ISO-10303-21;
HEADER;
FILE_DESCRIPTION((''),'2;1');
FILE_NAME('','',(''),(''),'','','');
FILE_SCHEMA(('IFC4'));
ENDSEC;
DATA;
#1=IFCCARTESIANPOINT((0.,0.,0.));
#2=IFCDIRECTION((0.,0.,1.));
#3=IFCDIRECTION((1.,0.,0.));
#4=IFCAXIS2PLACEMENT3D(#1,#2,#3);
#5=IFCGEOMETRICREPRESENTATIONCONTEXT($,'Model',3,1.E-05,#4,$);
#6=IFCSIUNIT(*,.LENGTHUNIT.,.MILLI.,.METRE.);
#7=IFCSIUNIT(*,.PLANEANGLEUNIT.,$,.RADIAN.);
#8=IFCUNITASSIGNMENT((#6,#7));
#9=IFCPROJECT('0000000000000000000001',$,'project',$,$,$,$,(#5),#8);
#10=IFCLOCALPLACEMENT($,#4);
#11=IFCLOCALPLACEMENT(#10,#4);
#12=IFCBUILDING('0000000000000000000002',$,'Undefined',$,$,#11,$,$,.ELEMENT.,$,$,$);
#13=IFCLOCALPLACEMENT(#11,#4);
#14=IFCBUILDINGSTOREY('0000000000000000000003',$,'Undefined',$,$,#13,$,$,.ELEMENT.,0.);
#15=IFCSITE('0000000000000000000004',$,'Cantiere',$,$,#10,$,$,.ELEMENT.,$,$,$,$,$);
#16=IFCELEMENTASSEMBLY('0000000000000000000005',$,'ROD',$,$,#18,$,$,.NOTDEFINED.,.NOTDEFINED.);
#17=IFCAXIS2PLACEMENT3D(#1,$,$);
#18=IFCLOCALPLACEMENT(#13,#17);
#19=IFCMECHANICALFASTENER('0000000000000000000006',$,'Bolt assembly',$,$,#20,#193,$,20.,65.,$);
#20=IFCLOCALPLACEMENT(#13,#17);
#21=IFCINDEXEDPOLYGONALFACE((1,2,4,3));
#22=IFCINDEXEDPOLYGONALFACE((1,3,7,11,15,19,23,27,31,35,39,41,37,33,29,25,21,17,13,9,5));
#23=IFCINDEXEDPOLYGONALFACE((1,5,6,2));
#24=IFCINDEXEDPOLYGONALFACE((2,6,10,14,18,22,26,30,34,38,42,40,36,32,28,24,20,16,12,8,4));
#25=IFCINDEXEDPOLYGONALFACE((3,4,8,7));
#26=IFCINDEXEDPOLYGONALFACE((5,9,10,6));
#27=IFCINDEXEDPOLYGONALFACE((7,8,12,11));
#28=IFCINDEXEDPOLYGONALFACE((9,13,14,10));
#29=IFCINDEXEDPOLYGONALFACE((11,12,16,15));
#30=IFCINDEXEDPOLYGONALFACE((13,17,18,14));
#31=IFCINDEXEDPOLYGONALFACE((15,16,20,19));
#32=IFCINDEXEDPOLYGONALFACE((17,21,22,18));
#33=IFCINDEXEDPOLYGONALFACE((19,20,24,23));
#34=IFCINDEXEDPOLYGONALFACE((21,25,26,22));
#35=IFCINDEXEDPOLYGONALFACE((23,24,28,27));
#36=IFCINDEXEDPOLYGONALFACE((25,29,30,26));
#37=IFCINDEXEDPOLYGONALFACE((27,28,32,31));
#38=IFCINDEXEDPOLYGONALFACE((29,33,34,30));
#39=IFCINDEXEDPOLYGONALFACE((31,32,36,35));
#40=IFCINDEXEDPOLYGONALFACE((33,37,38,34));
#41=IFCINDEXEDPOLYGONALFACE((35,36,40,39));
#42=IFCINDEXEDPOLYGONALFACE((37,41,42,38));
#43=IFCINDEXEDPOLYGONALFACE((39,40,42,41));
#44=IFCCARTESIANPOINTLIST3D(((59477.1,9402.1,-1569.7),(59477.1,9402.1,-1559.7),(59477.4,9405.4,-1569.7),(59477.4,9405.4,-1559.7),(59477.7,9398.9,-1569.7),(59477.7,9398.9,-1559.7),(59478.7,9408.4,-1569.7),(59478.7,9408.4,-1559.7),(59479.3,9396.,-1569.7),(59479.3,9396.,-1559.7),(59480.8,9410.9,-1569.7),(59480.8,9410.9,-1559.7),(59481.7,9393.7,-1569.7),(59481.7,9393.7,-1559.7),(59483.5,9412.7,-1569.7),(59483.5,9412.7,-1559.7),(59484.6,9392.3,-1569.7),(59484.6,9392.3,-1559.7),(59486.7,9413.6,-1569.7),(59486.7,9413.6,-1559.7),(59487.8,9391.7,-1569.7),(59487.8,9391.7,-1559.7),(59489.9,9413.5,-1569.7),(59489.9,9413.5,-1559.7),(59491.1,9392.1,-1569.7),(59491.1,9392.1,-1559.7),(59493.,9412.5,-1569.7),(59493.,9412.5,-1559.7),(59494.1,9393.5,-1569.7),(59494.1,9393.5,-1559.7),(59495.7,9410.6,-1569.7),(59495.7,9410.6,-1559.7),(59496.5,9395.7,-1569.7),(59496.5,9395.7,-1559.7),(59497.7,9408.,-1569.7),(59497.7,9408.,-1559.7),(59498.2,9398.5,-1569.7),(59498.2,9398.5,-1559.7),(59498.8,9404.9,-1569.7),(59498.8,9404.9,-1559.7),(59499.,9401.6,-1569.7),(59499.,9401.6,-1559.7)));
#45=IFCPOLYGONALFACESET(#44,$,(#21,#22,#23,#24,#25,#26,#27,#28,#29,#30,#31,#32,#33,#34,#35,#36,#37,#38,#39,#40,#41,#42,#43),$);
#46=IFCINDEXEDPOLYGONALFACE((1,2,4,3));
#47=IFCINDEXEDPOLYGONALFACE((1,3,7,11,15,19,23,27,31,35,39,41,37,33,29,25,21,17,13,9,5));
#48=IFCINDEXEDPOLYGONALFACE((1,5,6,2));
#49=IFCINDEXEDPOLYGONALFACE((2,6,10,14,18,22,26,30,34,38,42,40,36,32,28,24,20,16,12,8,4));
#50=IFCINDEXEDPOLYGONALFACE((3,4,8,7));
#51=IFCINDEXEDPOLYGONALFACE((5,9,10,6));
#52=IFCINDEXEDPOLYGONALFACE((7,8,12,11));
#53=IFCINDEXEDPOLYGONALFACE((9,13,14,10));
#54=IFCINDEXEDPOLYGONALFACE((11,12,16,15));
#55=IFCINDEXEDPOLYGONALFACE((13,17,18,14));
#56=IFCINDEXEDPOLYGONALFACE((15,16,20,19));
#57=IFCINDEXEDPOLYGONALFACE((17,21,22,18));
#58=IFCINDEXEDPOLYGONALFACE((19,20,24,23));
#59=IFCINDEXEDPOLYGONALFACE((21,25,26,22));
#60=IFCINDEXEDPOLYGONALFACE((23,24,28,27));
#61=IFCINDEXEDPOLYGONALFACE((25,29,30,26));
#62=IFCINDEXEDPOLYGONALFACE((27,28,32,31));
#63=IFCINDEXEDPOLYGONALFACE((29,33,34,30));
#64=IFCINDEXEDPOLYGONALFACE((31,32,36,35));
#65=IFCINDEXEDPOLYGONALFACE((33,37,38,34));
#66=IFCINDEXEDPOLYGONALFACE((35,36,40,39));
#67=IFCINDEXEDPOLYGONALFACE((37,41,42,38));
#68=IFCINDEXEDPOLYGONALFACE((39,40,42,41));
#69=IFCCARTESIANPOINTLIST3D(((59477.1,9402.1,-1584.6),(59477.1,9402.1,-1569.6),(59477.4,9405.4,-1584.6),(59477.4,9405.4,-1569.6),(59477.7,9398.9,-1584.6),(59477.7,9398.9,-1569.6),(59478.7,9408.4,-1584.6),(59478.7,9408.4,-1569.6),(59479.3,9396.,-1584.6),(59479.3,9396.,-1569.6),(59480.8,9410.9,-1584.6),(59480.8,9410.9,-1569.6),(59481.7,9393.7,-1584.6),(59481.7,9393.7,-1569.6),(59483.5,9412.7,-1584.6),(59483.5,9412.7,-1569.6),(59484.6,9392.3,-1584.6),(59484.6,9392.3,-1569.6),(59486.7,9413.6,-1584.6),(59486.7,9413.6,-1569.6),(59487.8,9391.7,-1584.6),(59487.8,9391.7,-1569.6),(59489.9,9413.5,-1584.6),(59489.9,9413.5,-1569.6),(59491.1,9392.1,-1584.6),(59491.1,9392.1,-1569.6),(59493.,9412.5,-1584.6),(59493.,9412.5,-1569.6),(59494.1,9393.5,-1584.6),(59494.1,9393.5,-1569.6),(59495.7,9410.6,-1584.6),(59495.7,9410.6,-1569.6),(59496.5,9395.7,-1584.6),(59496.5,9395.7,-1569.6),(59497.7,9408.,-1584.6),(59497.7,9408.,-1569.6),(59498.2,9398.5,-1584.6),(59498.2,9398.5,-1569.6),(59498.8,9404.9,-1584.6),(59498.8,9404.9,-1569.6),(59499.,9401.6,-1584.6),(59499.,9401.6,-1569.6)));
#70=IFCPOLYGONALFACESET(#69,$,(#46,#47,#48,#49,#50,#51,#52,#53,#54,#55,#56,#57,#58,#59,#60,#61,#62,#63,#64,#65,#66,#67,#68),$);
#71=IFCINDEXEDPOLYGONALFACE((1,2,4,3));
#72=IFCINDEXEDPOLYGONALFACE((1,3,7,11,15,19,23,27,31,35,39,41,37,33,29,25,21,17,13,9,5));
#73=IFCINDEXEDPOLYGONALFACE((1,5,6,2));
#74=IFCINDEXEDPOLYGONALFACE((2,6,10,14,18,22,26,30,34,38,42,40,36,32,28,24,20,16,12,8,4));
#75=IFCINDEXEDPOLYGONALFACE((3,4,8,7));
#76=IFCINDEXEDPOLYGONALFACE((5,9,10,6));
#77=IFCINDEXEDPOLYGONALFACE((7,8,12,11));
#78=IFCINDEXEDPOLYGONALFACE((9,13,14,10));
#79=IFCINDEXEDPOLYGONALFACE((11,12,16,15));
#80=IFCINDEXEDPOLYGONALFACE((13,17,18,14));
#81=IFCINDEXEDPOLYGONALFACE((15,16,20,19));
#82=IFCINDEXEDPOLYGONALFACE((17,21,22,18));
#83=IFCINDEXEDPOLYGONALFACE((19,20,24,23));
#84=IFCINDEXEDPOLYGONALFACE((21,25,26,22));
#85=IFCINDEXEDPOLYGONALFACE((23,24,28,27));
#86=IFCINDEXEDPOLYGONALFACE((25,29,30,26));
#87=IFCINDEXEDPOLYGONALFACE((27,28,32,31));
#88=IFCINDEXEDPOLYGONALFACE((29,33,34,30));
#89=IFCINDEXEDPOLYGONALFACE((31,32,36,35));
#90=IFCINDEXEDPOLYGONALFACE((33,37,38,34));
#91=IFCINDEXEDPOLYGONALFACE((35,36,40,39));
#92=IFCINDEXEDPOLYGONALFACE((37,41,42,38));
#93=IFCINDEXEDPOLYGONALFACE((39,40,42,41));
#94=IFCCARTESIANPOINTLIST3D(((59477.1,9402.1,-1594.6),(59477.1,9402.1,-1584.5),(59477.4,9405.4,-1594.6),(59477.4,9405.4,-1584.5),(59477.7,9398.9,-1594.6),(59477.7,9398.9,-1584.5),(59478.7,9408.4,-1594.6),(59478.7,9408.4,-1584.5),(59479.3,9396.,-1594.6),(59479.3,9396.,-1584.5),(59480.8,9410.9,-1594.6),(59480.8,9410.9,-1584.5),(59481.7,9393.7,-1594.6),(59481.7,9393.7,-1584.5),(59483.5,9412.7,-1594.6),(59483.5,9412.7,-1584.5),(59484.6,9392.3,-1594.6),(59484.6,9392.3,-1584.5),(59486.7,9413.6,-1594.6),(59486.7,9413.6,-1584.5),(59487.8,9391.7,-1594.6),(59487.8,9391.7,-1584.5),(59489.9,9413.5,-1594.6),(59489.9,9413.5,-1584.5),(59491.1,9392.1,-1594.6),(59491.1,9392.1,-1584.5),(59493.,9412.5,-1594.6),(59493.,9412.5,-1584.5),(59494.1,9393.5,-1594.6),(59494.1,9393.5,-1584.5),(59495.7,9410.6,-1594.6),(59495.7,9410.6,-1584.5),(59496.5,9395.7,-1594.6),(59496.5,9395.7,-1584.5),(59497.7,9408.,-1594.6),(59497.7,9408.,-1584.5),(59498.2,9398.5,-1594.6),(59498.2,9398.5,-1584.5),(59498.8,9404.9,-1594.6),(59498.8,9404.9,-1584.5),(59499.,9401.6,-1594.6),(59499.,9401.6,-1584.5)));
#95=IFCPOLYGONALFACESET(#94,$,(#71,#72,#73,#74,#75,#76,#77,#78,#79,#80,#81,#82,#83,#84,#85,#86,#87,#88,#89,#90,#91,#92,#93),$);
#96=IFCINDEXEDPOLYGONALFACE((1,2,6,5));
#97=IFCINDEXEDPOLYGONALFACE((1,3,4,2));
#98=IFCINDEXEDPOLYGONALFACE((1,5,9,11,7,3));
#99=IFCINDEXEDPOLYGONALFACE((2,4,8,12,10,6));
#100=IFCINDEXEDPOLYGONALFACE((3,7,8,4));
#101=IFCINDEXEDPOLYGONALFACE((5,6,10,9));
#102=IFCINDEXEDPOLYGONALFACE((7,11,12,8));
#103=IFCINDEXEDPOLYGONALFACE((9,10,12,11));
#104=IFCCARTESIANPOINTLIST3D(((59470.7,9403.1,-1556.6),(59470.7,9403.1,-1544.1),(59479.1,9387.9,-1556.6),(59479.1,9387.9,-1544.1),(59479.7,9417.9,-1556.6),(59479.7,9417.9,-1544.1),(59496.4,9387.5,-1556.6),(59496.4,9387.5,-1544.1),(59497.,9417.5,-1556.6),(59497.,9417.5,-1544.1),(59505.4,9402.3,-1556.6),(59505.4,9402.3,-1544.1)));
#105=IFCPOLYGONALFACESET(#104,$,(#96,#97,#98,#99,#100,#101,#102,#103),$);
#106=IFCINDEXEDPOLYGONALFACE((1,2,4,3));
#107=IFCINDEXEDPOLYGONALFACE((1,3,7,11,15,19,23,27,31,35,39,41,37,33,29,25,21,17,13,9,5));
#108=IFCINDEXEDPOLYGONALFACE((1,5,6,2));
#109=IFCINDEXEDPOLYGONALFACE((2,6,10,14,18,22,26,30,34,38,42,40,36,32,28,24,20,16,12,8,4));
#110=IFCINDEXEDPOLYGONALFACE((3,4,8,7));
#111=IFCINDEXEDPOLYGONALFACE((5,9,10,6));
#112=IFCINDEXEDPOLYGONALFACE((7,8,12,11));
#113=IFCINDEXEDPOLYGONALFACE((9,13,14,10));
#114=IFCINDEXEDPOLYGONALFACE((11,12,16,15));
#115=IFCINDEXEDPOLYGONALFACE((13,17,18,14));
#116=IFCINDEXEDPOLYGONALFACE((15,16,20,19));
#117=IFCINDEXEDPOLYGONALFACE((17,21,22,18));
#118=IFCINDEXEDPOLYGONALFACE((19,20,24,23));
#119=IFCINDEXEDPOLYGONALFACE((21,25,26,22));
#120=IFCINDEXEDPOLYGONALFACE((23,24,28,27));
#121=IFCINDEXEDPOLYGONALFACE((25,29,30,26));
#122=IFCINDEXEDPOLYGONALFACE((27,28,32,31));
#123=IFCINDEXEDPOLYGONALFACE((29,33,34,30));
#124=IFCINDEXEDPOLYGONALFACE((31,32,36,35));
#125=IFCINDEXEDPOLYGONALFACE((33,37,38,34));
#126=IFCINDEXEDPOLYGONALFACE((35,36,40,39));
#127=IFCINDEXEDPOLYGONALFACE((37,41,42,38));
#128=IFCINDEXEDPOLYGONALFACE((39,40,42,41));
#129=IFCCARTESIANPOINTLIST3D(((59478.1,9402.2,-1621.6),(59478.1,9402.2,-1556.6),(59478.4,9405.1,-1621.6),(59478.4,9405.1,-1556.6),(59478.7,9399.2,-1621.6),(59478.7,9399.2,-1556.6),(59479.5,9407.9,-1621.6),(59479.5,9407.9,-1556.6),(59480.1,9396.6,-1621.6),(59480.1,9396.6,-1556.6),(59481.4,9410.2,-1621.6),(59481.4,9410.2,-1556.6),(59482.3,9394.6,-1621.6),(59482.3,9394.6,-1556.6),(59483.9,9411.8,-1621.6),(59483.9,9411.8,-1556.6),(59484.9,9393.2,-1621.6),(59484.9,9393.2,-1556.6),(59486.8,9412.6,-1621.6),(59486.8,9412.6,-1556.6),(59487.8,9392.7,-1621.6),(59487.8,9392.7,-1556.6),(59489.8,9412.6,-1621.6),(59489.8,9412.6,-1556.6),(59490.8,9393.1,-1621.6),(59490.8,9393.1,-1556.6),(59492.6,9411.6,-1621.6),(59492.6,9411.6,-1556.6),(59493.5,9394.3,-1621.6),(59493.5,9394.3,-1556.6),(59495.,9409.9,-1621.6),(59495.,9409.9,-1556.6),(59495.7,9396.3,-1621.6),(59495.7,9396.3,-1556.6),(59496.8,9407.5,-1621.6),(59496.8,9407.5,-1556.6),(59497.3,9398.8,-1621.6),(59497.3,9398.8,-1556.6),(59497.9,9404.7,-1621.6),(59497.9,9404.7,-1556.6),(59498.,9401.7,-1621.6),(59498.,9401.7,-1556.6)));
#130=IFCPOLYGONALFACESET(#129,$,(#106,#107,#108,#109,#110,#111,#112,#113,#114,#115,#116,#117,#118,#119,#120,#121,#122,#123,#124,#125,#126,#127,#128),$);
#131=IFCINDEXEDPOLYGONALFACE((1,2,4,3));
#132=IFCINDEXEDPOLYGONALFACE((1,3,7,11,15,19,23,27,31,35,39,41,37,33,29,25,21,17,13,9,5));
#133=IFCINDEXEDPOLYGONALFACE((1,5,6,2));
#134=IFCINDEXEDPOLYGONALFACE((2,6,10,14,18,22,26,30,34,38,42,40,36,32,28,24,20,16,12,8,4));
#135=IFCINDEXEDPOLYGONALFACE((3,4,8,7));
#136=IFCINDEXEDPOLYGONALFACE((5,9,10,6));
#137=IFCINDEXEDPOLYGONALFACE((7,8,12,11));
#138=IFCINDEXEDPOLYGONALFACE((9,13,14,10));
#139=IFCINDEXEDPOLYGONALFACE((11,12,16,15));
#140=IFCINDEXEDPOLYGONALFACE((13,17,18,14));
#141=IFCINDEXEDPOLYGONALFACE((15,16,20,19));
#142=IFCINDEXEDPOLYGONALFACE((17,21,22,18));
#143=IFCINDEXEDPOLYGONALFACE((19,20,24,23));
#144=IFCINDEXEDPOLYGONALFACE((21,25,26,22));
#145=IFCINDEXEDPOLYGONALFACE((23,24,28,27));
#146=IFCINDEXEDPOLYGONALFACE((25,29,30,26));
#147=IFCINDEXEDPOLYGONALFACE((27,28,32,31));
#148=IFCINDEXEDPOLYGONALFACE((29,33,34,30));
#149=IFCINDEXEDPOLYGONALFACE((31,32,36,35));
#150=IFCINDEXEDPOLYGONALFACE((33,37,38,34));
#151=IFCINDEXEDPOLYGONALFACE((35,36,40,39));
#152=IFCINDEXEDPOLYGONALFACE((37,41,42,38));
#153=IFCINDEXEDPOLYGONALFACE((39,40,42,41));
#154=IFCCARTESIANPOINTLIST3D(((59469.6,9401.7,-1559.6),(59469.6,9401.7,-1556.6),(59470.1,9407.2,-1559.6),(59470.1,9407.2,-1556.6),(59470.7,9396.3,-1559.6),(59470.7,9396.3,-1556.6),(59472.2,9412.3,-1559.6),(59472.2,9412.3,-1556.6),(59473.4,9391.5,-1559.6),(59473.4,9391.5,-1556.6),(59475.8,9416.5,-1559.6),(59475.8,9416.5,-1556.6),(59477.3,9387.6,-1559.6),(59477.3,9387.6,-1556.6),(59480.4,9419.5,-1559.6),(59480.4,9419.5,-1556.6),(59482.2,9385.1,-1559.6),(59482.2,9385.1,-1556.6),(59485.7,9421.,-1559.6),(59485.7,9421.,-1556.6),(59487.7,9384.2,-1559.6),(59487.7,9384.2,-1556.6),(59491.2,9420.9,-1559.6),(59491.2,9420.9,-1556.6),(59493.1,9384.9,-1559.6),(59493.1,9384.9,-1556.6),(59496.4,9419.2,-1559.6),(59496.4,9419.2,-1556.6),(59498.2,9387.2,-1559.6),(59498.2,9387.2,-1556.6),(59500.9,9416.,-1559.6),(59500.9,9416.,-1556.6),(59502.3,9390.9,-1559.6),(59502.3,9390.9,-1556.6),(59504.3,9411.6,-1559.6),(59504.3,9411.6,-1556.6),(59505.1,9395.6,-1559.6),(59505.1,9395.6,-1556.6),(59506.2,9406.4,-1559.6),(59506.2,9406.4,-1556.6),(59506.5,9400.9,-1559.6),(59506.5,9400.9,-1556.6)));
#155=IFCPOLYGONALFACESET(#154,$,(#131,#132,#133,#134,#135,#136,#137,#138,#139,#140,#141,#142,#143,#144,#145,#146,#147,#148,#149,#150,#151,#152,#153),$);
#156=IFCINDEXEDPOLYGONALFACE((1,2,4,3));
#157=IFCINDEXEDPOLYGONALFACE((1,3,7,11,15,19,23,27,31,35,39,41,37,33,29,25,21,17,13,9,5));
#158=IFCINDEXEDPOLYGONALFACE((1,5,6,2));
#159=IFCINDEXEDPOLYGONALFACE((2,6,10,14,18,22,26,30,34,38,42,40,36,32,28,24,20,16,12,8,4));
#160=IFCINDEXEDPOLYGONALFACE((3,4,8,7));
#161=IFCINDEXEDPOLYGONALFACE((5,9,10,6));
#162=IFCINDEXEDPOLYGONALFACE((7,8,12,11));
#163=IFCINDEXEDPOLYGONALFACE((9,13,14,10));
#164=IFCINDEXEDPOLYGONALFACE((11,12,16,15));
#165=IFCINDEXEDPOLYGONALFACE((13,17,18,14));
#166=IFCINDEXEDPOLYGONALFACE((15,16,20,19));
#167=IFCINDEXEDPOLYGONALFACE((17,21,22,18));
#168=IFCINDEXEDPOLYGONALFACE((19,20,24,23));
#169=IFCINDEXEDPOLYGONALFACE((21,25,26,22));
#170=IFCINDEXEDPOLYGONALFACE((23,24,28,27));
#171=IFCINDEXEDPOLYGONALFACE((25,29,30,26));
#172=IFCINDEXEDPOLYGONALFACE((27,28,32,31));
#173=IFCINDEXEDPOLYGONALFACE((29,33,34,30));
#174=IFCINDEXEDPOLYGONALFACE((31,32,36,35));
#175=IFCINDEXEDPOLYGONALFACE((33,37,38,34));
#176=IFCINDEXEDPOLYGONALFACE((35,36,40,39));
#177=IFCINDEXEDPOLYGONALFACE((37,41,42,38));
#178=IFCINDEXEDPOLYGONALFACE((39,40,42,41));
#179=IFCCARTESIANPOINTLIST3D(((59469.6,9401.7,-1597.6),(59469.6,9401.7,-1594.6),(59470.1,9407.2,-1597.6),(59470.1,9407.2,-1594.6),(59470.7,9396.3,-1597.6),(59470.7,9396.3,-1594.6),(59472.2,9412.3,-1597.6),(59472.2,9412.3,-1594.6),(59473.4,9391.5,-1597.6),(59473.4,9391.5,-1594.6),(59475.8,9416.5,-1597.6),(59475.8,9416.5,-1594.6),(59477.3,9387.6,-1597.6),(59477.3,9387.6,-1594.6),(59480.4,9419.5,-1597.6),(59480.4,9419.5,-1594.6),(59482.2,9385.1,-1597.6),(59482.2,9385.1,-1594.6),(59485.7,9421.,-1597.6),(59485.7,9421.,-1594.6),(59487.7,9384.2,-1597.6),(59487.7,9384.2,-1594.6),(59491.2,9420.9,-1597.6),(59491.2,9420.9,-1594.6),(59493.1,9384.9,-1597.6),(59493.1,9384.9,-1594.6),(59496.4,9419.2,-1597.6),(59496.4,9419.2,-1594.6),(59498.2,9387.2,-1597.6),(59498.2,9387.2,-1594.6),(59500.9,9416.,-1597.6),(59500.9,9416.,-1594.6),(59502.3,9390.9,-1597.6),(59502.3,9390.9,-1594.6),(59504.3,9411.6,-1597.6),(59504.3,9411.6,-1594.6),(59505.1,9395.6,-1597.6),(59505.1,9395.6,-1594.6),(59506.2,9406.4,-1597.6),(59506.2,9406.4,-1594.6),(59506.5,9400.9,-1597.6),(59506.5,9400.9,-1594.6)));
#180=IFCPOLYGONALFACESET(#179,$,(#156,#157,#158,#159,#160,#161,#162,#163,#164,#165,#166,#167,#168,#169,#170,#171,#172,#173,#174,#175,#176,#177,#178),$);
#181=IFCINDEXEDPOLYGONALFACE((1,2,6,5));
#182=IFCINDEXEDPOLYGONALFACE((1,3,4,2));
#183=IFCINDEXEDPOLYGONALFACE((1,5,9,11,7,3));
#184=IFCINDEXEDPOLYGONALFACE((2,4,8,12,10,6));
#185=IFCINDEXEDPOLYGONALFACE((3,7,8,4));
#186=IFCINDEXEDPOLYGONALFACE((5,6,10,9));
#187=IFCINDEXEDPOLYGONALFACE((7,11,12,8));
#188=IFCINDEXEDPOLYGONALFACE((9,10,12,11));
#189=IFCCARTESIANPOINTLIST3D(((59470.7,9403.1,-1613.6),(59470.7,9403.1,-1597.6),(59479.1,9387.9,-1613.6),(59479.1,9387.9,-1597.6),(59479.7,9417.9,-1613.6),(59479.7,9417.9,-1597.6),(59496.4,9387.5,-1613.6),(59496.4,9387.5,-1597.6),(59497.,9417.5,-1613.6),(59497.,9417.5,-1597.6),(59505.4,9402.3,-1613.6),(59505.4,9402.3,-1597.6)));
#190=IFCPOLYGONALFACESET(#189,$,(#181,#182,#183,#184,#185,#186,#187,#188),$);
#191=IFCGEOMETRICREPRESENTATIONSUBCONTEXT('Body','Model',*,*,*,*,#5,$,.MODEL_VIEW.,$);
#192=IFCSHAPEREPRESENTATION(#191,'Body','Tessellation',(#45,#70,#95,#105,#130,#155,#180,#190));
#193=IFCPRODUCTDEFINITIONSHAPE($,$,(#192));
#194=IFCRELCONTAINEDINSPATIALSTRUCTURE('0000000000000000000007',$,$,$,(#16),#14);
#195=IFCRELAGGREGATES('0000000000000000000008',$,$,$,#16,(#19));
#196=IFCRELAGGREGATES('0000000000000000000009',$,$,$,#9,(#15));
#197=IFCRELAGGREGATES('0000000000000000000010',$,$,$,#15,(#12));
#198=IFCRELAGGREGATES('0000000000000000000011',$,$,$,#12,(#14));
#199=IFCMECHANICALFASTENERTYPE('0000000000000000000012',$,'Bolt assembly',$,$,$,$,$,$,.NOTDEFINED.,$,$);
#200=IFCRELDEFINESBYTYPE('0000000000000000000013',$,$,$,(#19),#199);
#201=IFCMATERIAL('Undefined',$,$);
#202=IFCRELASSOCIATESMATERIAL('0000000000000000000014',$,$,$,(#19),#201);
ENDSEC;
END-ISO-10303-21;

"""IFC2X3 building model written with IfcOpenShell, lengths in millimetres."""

from ifc_helpers import new_model, si_unit, frame, origin_with_axes, origin_2d_with_axis, place, context, subcontext, project, spatial, polyline, circle, outline, extrude, source, transform, mapped, material, type_object, element, aggregate, save


model = new_model("IFC2X3")

# Units and contexts
model_context = context("Model", 3, precision=1e-05, world=origin_with_axes())
body_context = subcontext(model_context, "Body", "Model", "MODEL_VIEW")
ifc_project = project(units=[si_unit("LENGTHUNIT", "METRE", prefix="MILLI"), si_unit("PLANEANGLEUNIT", "RADIAN")], contexts=[model_context])

# Site, building, storey
site_placement = place(None, origin_with_axes())
site = spatial("IfcSite", under=ifc_project, at=site_placement, Name="Cantiere", CompositionType="ELEMENT")
building_placement = place(site_placement, origin_with_axes())
building = spatial("IfcBuilding", under=site, at=building_placement, Name="Undefined", CompositionType="ELEMENT")
storey_placement = place(building_placement, origin_with_axes())
storey = spatial("IfcBuildingStorey", under=building, at=storey_placement, Name="Undefined", CompositionType="ELEMENT", Elevation=0.0)

# Element assembly
assembly_1_placement = place(storey_placement, origin_with_axes())
assembly_1 = element("IfcElementAssembly", 1, at=assembly_1_placement, inside=storey, Name="ROD", AssemblyPlace="NOTDEFINED", PredefinedType="NOTDEFINED")

# Mechanical fastener
ifc_material_1 = material(Name="Undefined")
mechanical_fastener_type = type_object("IfcMechanicalFastenerType", Name="Bolt assembly")
shared_shape_1 = source(origin_with_axes(), body_context, "Body", "SweptSolid", [
    extrude(circle(Radius=11.0, at=origin_2d_with_axis()), frame((0.0, 0.1, 0.0), z_axis=(0.0, 1.0, 0.0), x_axis=(1.0, 0.0, 0.0)), (0.0, 0.0, 1.0), 10.0),
    extrude(circle(Radius=11.0, at=origin_2d_with_axis()), frame((0.0, 10.0, 0.0), z_axis=(0.0, 1.0, 0.0), x_axis=(1.0, 0.0, 0.0)), (0.0, 0.0, 1.0), 15.0),
    extrude(circle(Radius=11.0, at=origin_2d_with_axis()), frame((0.0, 24.9, 0.0), z_axis=(0.0, 1.0, 0.0), x_axis=(1.0, 0.0, 0.0)), (0.0, 0.0, 1.0), 10.1),
    extrude(outline(polyline([(15.0, -8.7), (15.0, 8.7), (0.0, 17.3), (-15.0, 8.7), (-15.0, -8.7), (0.0, -17.3), (15.0, -8.7)])), frame((0.0, -15.5, 0.0), z_axis=(0.0, 1.0, 0.0), x_axis=(1.0, 0.0, 0.0)), (0.0, 0.0, 1.0), 12.5),
    extrude(circle(Radius=10.0, at=origin_2d_with_axis()), frame((0.0, -3.0, 0.0), z_axis=(0.0, 1.0, 0.0), x_axis=(1.0, 0.0, 0.0)), (0.0, 0.0, 1.0), 65.0),
    extrude(circle(Radius=18.5, at=origin_2d_with_axis()), frame((0.0, -3.0, 0.0), z_axis=(0.0, 1.0, 0.0), x_axis=(1.0, 0.0, 0.0)), (0.0, 0.0, 1.0), 3.0),
    extrude(circle(Radius=18.5, at=origin_2d_with_axis()), frame((0.0, 35.0, 0.0), z_axis=(0.0, 1.0, 0.0), x_axis=(1.0, 0.0, 0.0)), (0.0, 0.0, 1.0), 3.0),
    extrude(outline(polyline([(15.0, -8.7), (15.0, 8.7), (0.0, 17.3), (-15.0, 8.7), (-15.0, -8.7), (0.0, -17.3), (15.0, -8.7)])), frame((0.0, 38.0, 0.0), z_axis=(0.0, 1.0, 0.0), x_axis=(1.0, 0.0, 0.0)), (0.0, 0.0, 1.0), 16.0),
])
mechanical_fastener_1_placement = place(assembly_1_placement, frame((59488.1, 9402.7, -1559.6), z_axis=(0.999775, -0.021213, 0.0), x_axis=(-0.021213, -0.999775, -0.000001)))
mechanical_fastener_1 = element("IfcMechanicalFastener", 2, at=mechanical_fastener_1_placement, type_object=mechanical_fastener_type, material=ifc_material_1, Name="Bolt assembly", NominalDiameter=20.0, NominalLength=65.0, context=body_context, shape_type="MappedRepresentation", body=[
    mapped(shared_shape_1, transform((0.0, 0.0, 0.0))),
])
aggregate(assembly_1, [mechanical_fastener_1])

save(model, "model.ifc")
